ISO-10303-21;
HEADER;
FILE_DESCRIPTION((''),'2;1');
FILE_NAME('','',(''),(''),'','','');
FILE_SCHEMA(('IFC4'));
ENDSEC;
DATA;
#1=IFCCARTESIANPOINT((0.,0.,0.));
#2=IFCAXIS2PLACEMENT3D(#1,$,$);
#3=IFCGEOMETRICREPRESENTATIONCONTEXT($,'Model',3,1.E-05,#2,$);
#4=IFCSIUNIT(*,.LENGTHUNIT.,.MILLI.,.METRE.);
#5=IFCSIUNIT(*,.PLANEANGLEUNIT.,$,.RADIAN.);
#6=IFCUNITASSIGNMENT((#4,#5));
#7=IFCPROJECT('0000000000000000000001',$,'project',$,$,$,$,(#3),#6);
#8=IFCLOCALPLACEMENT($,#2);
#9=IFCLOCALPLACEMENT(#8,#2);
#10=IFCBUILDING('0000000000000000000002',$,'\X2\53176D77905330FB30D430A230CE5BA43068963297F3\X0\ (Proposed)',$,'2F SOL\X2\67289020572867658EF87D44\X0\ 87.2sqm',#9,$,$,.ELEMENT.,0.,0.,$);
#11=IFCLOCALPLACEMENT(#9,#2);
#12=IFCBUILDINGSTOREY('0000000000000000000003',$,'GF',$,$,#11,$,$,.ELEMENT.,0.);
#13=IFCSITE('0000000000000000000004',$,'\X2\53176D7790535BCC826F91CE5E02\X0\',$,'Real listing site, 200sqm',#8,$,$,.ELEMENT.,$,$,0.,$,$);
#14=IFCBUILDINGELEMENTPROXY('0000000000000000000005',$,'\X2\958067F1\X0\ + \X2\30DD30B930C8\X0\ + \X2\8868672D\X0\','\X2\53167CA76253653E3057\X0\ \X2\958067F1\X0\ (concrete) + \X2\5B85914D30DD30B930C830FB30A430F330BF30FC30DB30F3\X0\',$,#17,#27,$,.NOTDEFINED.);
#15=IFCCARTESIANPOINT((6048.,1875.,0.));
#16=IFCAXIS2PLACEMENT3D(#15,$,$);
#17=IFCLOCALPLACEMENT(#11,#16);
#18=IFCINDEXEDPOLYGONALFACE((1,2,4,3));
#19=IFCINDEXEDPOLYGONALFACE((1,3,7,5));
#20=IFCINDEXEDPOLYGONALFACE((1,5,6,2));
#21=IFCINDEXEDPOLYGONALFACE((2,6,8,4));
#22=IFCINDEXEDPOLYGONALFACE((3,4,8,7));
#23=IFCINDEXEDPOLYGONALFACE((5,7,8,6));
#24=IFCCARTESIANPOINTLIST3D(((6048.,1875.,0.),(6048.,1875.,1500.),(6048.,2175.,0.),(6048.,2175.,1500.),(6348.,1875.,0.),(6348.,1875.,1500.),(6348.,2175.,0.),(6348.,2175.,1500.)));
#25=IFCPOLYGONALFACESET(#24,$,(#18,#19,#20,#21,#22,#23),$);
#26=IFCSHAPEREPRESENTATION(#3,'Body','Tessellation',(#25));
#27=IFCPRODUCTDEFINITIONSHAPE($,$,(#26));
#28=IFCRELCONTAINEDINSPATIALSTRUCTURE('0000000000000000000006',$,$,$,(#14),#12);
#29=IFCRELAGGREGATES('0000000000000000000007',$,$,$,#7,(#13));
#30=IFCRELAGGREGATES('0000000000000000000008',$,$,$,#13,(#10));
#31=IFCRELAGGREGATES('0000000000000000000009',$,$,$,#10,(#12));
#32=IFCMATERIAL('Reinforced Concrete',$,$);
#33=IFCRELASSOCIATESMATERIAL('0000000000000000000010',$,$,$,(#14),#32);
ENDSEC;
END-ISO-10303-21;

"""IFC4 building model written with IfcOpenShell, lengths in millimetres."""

from ifc_helpers import new_model, si_unit, frame, frame_2d, origin, place, context, project, spatial, rectangle, extrude, material, element, save


model = new_model("IFC4")

# Units and contexts
model_context = context("Model", 3, precision=1e-05, world=origin())
ifc_project = project(units=[si_unit("LENGTHUNIT", "METRE", prefix="MILLI"), si_unit("PLANEANGLEUNIT", "RADIAN")], contexts=[model_context])

# Site, building, storey
site_placement = place(None, origin())
site = spatial("IfcSite", under=ifc_project, at=site_placement, Name="北海道富良野市", ObjectType="Real listing site, 200sqm", CompositionType="ELEMENT", RefElevation=0.0)
building_placement = place(site_placement, origin())
building = spatial("IfcBuilding", under=site, at=building_placement, Name="北海道・ピアノ室と防音 (Proposed)", ObjectType="2F SOL木造在来軸組 87.2sqm", CompositionType="ELEMENT", ElevationOfRefHeight=0.0, ElevationOfTerrain=0.0)
storey_placement = place(building_placement, origin())
storey = spatial("IfcBuildingStorey", under=building, at=storey_placement, Name="GF", CompositionType="ELEMENT", Elevation=0.0)

# Shared definitions
ifc_material_1 = material(Name="Reinforced Concrete")

# Building element proxy
proxy_placement = place(storey_placement, frame((6048.0, 1875.0, 0.0)))
element("IfcBuildingElementProxy", 1, at=proxy_placement, inside=storey, material=ifc_material_1, Name="門柱 + ポスト + 表札", Description="化粧打放し 門柱 (concrete) + 宅配ポスト・インターホン", PredefinedType="NOTDEFINED", context=model_context, shape_type="SweptSolid", body=[
    extrude(rectangle(XDim=300.0, YDim=300.0, at=frame_2d((150.0, 150.0))), frame((6048.0, 1875.0, 0.0)), (0.0, 0.0, 1.0), 1500.0),
])

save(model, "model.ifc")
